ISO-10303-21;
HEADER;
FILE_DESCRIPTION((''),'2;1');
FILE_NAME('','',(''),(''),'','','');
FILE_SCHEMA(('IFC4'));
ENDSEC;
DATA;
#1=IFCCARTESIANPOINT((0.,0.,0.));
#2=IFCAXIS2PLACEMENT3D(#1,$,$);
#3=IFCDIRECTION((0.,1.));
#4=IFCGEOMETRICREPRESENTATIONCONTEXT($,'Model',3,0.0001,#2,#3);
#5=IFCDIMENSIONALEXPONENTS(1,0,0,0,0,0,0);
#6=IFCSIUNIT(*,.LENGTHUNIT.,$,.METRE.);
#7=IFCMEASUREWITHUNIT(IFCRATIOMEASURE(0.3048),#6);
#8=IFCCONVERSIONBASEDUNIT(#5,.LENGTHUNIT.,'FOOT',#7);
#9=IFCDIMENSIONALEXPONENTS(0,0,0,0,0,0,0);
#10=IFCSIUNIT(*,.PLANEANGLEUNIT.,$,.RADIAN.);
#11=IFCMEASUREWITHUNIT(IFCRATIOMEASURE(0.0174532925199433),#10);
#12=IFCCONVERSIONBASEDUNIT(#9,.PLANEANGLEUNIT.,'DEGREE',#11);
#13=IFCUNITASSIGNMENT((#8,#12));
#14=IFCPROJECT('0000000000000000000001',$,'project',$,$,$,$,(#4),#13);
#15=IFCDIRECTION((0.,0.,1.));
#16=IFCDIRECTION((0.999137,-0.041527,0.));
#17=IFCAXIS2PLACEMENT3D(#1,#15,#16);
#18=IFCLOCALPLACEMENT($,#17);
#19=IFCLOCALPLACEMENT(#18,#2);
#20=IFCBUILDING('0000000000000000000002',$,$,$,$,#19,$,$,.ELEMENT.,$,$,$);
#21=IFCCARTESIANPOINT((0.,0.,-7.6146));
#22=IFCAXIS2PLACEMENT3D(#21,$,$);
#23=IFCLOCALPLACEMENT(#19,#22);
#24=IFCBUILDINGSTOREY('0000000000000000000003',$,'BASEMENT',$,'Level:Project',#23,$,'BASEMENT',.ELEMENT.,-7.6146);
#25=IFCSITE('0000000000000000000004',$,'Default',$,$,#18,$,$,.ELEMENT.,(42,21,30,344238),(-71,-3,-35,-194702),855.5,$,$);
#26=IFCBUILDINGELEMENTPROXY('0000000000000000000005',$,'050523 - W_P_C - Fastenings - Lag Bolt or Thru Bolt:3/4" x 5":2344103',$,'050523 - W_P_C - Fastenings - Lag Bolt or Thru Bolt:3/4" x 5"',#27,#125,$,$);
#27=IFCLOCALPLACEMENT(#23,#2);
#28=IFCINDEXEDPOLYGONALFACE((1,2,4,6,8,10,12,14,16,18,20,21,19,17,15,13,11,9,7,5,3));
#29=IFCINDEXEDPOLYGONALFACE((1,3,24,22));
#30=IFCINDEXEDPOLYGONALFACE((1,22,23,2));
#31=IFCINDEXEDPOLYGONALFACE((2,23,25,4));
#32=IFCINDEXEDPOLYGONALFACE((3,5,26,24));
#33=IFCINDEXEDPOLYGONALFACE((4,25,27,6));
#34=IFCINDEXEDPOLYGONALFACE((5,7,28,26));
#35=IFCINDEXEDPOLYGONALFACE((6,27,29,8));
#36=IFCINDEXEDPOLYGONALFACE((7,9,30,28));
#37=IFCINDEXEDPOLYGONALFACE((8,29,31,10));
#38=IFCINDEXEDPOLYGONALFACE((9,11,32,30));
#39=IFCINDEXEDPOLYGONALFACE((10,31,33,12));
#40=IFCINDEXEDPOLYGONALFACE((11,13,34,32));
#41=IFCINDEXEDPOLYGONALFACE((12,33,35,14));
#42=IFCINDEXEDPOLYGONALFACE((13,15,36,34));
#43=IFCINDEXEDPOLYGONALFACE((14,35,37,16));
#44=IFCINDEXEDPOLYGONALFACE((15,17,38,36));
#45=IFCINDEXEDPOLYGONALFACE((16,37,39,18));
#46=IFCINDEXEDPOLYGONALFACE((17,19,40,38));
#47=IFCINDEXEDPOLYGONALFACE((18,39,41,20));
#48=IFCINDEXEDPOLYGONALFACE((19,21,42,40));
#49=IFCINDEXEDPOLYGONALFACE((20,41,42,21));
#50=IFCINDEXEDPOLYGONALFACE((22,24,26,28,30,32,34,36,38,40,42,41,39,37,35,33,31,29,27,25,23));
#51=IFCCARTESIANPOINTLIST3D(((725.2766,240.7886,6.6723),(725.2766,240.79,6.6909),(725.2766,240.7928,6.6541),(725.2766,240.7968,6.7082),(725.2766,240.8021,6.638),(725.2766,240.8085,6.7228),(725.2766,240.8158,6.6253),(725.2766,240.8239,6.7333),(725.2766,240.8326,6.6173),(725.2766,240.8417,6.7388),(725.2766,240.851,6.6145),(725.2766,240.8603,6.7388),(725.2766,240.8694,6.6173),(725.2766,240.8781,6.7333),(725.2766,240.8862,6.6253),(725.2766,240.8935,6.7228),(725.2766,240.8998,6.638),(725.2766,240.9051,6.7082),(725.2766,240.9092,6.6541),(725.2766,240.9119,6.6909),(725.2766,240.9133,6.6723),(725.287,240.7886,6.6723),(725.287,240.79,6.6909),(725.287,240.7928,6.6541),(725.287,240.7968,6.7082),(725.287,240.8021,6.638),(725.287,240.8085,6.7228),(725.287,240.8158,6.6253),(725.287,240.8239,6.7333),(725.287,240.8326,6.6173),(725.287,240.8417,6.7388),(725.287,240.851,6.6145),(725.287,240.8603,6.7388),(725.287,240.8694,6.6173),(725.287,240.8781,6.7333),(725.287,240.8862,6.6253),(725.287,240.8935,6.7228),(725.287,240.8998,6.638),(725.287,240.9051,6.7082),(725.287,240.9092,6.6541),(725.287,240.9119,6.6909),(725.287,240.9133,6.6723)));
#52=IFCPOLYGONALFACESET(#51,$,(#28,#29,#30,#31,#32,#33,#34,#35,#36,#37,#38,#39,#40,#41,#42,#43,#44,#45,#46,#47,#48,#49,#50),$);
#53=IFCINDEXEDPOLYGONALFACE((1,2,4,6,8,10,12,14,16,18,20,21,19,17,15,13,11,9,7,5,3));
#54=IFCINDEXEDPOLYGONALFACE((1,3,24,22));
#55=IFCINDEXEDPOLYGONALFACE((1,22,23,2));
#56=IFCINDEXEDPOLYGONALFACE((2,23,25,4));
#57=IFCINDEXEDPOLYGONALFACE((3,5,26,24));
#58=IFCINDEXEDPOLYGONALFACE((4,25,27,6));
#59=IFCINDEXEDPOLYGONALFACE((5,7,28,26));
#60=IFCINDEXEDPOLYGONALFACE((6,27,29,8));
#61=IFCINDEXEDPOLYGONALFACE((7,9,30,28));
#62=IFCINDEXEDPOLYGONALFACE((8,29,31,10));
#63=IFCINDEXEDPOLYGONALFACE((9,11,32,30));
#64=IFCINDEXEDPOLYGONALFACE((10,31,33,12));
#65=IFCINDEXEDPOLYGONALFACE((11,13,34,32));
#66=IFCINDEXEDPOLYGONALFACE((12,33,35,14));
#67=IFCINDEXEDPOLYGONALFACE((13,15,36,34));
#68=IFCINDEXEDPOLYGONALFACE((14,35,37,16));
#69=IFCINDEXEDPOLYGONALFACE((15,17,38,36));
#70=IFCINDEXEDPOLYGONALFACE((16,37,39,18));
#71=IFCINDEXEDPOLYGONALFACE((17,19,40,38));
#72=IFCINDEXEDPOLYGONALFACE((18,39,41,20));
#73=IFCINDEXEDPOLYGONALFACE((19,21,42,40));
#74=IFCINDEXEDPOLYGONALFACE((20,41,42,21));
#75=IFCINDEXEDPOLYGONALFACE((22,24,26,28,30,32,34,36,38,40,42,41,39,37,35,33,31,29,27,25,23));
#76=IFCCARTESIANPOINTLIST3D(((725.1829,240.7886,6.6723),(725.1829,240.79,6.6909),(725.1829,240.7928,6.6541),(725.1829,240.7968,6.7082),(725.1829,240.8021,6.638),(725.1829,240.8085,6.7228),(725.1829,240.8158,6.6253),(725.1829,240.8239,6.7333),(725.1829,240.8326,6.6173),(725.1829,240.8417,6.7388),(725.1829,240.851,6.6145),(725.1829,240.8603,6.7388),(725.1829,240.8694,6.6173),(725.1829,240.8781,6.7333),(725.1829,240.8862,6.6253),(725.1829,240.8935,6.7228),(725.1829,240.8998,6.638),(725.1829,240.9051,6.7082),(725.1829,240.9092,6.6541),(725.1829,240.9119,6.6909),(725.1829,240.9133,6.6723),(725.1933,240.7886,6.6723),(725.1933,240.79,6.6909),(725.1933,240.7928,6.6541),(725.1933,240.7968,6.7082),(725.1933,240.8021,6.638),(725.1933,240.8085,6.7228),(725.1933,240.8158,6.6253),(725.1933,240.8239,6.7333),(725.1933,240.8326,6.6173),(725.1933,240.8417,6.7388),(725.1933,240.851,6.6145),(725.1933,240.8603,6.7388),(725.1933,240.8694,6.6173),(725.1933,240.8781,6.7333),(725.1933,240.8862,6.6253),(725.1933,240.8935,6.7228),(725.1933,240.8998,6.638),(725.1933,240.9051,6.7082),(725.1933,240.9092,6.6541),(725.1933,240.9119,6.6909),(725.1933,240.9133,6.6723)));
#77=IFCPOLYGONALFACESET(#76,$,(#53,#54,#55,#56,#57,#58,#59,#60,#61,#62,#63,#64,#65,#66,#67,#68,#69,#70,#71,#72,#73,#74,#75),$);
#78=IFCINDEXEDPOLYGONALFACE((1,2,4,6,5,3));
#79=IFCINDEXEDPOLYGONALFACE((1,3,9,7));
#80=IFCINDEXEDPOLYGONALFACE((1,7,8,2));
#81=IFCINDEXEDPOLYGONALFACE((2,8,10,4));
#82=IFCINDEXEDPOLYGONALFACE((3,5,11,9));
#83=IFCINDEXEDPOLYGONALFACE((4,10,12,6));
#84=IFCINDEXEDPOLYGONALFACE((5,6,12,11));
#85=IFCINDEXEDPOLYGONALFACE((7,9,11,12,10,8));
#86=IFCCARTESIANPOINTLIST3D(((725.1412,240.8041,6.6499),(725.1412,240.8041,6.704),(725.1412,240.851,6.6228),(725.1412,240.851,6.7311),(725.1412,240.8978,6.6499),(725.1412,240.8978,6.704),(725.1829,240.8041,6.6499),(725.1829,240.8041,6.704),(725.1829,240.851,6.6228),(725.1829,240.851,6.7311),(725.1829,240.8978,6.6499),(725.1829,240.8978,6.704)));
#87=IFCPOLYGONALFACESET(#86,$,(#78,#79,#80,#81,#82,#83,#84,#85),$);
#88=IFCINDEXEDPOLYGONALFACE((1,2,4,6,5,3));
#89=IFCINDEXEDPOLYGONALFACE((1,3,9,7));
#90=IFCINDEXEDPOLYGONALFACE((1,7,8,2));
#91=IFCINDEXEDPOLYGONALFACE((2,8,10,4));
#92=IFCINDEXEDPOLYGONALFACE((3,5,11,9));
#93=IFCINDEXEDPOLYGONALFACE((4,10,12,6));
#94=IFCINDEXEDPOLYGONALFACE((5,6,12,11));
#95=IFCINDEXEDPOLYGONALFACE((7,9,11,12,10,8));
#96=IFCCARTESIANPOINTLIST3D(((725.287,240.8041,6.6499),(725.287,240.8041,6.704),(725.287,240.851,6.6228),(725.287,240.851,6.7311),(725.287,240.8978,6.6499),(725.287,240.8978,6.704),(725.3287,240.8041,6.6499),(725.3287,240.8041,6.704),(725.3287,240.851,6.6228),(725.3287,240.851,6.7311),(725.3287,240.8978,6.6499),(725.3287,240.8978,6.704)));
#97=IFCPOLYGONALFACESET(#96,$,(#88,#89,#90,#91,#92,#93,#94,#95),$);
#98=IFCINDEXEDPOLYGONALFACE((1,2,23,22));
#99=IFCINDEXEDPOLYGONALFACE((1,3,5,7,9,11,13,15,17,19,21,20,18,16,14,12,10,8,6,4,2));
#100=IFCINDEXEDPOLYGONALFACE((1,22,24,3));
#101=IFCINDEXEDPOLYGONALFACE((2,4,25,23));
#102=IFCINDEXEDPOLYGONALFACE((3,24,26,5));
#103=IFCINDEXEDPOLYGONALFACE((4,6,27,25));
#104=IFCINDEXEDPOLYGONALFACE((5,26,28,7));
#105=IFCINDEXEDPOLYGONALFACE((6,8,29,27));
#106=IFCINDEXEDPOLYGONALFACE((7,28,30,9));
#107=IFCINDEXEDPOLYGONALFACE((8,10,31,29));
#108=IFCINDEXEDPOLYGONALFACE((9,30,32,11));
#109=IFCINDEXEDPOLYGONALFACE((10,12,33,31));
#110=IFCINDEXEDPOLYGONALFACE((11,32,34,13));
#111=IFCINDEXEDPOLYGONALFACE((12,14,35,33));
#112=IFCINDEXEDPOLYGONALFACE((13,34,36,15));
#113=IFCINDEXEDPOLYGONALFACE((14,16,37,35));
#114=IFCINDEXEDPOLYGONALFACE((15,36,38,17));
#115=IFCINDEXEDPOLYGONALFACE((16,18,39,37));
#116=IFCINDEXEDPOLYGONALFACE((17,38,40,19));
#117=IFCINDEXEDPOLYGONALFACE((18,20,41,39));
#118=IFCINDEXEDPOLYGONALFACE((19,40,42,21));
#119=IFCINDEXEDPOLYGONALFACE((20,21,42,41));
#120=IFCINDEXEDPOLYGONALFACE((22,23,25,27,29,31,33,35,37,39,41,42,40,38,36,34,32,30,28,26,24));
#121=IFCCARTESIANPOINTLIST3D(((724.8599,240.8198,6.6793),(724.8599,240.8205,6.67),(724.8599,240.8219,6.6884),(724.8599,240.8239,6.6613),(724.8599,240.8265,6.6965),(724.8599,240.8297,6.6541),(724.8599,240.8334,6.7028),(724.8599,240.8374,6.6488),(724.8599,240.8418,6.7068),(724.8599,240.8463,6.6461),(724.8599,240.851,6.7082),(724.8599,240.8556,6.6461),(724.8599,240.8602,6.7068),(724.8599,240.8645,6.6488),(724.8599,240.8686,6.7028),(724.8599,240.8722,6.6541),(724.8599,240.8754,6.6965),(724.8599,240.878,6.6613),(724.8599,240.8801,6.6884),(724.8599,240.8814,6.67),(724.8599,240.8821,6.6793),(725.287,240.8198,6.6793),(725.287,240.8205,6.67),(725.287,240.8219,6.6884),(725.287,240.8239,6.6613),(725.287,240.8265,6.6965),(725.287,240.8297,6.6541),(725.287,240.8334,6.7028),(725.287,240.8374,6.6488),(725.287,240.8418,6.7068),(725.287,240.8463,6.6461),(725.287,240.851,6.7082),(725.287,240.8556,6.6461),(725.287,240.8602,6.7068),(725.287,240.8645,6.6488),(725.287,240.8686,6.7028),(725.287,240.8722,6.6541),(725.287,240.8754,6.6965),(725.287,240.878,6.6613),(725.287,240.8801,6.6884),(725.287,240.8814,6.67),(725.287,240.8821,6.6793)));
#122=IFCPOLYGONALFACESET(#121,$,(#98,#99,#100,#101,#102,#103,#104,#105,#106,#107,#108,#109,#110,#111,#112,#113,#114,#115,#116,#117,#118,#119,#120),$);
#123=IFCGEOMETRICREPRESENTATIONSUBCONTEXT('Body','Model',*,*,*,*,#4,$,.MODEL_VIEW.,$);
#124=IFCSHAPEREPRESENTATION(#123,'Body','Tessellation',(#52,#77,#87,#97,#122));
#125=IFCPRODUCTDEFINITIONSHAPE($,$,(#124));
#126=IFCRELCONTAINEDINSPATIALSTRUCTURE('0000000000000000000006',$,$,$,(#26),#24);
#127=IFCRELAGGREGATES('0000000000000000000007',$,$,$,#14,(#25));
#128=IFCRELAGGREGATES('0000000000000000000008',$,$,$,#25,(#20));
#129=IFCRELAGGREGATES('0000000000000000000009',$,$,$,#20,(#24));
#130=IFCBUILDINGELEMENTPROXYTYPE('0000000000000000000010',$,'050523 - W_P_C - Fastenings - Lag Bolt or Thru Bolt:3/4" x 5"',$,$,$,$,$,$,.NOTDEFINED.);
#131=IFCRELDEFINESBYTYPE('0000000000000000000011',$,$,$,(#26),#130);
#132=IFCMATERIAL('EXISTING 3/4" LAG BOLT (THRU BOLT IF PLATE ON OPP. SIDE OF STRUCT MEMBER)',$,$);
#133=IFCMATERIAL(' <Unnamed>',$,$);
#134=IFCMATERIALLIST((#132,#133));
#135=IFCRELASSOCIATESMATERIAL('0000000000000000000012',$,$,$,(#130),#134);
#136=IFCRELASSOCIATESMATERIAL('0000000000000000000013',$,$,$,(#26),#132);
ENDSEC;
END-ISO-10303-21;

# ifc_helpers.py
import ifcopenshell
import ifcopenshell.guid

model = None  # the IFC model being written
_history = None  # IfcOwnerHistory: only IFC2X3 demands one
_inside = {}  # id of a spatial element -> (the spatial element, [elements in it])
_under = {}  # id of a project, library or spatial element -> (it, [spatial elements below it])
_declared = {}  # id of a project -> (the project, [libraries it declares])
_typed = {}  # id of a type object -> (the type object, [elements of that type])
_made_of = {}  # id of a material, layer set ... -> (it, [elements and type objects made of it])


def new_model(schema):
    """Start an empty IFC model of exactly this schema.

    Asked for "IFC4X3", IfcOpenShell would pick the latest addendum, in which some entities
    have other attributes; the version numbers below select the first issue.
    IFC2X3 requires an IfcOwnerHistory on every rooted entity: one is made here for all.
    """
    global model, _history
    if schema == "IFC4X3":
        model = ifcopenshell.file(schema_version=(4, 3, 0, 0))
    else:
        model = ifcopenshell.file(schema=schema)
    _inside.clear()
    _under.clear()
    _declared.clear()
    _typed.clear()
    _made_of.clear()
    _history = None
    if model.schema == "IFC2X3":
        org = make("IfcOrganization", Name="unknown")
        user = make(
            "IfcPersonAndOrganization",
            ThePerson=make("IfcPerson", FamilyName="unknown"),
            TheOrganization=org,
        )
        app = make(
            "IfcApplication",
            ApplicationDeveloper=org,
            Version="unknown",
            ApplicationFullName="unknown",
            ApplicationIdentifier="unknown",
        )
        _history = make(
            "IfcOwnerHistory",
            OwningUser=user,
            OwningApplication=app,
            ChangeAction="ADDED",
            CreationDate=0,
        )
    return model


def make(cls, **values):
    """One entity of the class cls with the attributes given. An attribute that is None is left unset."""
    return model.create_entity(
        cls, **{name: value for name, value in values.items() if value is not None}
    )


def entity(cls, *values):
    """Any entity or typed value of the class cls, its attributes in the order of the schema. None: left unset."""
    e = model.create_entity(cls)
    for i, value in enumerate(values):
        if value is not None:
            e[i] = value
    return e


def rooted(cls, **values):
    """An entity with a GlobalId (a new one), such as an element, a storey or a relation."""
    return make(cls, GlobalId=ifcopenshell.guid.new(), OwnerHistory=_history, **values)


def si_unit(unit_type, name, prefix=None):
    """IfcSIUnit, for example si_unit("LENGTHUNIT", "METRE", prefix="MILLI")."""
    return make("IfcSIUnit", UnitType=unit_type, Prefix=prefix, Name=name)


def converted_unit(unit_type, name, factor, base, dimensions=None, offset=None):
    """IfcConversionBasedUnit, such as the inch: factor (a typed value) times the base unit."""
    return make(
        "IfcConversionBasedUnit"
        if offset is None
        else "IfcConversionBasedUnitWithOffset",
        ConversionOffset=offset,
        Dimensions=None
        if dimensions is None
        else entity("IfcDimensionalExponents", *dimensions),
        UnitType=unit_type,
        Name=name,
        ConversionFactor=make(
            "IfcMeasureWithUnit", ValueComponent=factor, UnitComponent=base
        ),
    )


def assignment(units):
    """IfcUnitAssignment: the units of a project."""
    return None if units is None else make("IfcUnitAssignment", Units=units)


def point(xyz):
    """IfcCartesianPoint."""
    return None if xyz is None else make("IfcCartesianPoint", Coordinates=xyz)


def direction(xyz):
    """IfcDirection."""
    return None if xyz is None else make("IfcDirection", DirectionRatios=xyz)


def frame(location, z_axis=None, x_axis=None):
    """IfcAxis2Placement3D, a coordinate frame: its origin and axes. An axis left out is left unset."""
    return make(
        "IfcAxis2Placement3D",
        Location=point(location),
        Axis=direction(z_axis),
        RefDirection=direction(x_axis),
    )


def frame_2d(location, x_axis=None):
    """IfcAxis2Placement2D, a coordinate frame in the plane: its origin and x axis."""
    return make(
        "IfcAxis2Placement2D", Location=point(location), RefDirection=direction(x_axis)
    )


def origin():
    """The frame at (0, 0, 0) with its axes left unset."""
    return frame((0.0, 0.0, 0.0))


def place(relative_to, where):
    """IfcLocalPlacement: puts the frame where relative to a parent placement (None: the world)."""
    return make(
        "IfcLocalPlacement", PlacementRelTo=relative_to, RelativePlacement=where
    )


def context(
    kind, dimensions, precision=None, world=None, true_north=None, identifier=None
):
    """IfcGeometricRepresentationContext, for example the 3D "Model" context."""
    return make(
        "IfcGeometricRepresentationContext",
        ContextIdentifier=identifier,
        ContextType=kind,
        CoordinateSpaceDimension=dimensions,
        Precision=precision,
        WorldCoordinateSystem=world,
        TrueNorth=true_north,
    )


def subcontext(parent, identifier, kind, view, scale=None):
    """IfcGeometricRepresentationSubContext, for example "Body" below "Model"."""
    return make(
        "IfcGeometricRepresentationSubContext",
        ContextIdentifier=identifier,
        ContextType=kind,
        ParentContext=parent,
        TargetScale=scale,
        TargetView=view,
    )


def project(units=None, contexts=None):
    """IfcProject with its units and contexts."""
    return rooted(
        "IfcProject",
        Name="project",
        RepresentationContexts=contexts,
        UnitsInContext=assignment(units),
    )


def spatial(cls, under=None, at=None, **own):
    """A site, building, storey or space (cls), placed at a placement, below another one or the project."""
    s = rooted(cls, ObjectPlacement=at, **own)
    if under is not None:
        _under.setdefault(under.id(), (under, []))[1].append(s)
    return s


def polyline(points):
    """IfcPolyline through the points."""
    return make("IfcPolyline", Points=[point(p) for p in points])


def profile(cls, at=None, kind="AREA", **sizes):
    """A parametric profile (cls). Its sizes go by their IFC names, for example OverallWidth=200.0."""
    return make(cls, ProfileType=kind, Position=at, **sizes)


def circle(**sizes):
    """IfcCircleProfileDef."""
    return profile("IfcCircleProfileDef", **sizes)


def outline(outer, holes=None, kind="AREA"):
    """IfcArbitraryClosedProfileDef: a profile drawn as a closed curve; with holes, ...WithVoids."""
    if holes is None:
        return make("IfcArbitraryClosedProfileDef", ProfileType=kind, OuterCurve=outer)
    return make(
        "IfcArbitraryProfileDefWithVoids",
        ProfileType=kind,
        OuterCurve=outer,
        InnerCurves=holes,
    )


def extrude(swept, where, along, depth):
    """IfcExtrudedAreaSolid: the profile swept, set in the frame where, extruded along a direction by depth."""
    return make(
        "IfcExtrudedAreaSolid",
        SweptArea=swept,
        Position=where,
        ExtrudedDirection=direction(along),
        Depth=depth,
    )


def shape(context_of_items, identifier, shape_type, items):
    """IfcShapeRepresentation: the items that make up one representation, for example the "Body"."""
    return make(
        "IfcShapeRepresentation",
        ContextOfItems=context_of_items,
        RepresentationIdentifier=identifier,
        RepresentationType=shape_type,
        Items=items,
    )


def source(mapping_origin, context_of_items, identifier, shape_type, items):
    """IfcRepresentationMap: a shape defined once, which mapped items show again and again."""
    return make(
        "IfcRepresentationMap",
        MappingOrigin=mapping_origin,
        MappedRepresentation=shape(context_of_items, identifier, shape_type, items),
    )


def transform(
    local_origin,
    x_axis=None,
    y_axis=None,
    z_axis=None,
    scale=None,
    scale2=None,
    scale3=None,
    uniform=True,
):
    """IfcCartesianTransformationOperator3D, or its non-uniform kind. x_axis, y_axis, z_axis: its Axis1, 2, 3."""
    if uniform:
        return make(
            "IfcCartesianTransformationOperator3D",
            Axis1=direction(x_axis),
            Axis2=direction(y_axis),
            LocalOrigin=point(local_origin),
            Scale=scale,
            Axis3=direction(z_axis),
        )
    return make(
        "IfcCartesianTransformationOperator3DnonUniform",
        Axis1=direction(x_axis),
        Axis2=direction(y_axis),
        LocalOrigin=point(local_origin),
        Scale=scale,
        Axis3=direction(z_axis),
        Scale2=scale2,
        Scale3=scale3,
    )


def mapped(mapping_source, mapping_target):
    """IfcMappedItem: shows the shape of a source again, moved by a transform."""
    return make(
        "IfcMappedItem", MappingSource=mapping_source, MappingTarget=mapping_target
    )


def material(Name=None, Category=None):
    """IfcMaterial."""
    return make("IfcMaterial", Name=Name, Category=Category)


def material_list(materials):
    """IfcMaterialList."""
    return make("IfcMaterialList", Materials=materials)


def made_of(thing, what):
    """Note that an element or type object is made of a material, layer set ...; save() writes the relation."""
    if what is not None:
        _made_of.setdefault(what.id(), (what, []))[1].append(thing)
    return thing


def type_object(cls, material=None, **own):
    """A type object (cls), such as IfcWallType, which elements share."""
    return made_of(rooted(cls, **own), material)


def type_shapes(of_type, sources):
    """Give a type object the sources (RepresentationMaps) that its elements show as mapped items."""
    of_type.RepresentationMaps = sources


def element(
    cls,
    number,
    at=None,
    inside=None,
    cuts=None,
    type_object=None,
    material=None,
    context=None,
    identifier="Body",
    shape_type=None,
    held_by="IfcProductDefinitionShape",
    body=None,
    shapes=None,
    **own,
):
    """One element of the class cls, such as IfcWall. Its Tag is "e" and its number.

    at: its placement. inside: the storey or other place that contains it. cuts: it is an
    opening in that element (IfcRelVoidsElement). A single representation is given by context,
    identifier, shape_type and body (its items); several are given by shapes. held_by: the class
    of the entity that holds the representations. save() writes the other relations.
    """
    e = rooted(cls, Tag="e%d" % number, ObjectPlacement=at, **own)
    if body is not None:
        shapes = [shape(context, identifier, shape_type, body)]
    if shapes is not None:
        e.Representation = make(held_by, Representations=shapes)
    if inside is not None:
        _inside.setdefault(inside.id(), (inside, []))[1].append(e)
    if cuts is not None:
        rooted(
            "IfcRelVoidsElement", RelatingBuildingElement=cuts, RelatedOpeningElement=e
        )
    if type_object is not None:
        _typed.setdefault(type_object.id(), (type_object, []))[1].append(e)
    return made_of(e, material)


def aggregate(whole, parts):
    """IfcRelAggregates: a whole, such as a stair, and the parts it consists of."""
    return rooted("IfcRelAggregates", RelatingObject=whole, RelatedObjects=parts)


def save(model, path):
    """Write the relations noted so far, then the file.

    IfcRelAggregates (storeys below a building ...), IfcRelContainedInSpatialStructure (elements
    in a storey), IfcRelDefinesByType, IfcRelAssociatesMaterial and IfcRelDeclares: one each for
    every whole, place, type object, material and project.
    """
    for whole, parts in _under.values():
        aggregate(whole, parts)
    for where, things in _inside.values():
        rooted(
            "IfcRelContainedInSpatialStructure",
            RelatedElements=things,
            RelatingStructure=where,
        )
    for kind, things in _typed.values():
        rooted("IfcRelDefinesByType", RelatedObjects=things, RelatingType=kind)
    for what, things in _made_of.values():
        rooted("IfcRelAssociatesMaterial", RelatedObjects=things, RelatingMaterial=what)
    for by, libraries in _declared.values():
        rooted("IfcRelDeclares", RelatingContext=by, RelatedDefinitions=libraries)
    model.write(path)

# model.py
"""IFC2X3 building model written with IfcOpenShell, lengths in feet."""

from ifc_helpers import new_model, entity, si_unit, converted_unit, direction, frame, frame_2d, origin, place, context, subcontext, project, spatial, polyline, circle, outline, extrude, source, transform, mapped, material, material_list, type_object, type_shapes, element, save


model = new_model("IFC2X3")

# Units and contexts
model_context = context("Model", 3, precision=0.0001, world=origin(), true_north=direction((0.0, 1.0)))
body_context = subcontext(model_context, "Body", "Model", "MODEL_VIEW")
ifc_project = project(units=[converted_unit("LENGTHUNIT", "FOOT", entity("IfcRatioMeasure", 0.3048), si_unit("LENGTHUNIT", "METRE"), dimensions=[1, 0, 0, 0, 0, 0, 0]), converted_unit("PLANEANGLEUNIT", "DEGREE", entity("IfcRatioMeasure", 0.0174532925199433), si_unit("PLANEANGLEUNIT", "RADIAN"), dimensions=[0, 0, 0, 0, 0, 0, 0])], contexts=[model_context])

# Site, building, storey
site_placement = place(None, frame((0.0, 0.0, 0.0), z_axis=(0.0, 0.0, 1.0), x_axis=(0.999137, -0.041527, 0.0)))
site = spatial("IfcSite", under=ifc_project, at=site_placement, Name="Default", CompositionType="ELEMENT", RefLatitude=(42, 21, 30, 344238), RefLongitude=(-71, -3, -35, -194702), RefElevation=855.5)
building_placement = place(site_placement, origin())
building = spatial("IfcBuilding", under=site, at=building_placement, CompositionType="ELEMENT")
storey_placement = place(building_placement, frame((0.0, 0.0, -7.6146)))
storey = spatial("IfcBuildingStorey", under=building, at=storey_placement, Name="BASEMENT", ObjectType="Level:Project", LongName="BASEMENT", CompositionType="ELEMENT", Elevation=-7.6146)

# Building element proxy
ifc_material_1 = material(Name=" <Unnamed>")
ifc_material_2 = material(Name="EXISTING 3/4\" LAG BOLT (THRU BOLT IF PLATE ON OPP. SIDE OF STRUCT MEMBER)")
ifc_material_list_1 = material_list([ifc_material_2, ifc_material_1])
building_element_proxy_type_1 = type_object("IfcBuildingElementProxyType", Name="050523 - W_P_C - Fastenings - Lag Bolt or Thru Bolt:3/4\" x 5\"", PredefinedType="NOTDEFINED", material=ifc_material_list_1)
shared_shape_1 = source(origin(), body_context, "Body", "SweptSolid", [
    extrude(circle(Radius=0.0625, at=frame_2d((0.0, 0.0), x_axis=(1.0, 0.0))), frame((0.0, 0.0, 0.0), z_axis=(0.0, 0.0, 1.0), x_axis=(0.0, 1.0, 0.0)), (0.0, 0.0, 1.0), 0.0104),
    extrude(circle(Radius=0.0625, at=frame_2d((0.0, 0.0), x_axis=(1.0, 0.0))), frame((0.0, 0.0, -0.0938), z_axis=(0.0, 0.0, 1.0), x_axis=(0.0, 1.0, 0.0)), (0.0, 0.0, 1.0), 0.0104),
    extrude(outline(polyline([(-0.0271, -0.0469), (0.0271, -0.0469), (0.0541, 0.0), (0.0271, 0.0469), (-0.0271, 0.0469), (-0.0541, 0.0), (-0.0271, -0.0469)])), frame((0.0, 0.0, -0.1354), z_axis=(0.0, 0.0, 1.0), x_axis=(0.0, -1.0, 0.0)), (0.0, 0.0, 1.0), 0.0417),
    extrude(outline(polyline([(-0.0271, -0.0469), (0.0271, -0.0469), (0.0541, 0.0), (0.0271, 0.0469), (-0.0271, 0.0469), (-0.0541, 0.0), (-0.0271, -0.0469)])), frame((0.0, 0.0, 0.0104), z_axis=(0.0, 0.0, 1.0), x_axis=(0.866025, -0.5, 0.0)), (0.0, 0.0, 1.0), 0.0417),
    extrude(circle(Radius=0.0312, at=frame_2d((0.0, 0.0), x_axis=(1.0, 0.0))), frame((0.0, 0.0, -0.4167), z_axis=(0.0, 0.0, 1.0), x_axis=(0.0, -1.0, 0.0)), (0.0, 0.0, 1.0), 0.4271),
])
type_shapes(building_element_proxy_type_1, [shared_shape_1])
for number, where, z_axis, x_axis, name in (
    (1, (725.2766, 240.851, 6.677), (1.0, 0.0, 0.0), (0.0, -1.0, 0.0), "050523 - W_P_C - Fastenings - Lag Bolt or Thru Bolt:3/4\" x 5\":2344103"),
):
    element("IfcBuildingElementProxy", number, at=place(storey_placement, frame(where, z_axis=z_axis, x_axis=x_axis)), inside=storey, type_object=building_element_proxy_type_1, material=ifc_material_2, Name=name, ObjectType="050523 - W_P_C - Fastenings - Lag Bolt or Thru Bolt:3/4\" x 5\"", context=body_context, shape_type="MappedRepresentation", body=[
        mapped(shared_shape_1, transform((0.0, 0.0, 0.0), scale=1.0)),
    ])

save(model, "model.ifc")
